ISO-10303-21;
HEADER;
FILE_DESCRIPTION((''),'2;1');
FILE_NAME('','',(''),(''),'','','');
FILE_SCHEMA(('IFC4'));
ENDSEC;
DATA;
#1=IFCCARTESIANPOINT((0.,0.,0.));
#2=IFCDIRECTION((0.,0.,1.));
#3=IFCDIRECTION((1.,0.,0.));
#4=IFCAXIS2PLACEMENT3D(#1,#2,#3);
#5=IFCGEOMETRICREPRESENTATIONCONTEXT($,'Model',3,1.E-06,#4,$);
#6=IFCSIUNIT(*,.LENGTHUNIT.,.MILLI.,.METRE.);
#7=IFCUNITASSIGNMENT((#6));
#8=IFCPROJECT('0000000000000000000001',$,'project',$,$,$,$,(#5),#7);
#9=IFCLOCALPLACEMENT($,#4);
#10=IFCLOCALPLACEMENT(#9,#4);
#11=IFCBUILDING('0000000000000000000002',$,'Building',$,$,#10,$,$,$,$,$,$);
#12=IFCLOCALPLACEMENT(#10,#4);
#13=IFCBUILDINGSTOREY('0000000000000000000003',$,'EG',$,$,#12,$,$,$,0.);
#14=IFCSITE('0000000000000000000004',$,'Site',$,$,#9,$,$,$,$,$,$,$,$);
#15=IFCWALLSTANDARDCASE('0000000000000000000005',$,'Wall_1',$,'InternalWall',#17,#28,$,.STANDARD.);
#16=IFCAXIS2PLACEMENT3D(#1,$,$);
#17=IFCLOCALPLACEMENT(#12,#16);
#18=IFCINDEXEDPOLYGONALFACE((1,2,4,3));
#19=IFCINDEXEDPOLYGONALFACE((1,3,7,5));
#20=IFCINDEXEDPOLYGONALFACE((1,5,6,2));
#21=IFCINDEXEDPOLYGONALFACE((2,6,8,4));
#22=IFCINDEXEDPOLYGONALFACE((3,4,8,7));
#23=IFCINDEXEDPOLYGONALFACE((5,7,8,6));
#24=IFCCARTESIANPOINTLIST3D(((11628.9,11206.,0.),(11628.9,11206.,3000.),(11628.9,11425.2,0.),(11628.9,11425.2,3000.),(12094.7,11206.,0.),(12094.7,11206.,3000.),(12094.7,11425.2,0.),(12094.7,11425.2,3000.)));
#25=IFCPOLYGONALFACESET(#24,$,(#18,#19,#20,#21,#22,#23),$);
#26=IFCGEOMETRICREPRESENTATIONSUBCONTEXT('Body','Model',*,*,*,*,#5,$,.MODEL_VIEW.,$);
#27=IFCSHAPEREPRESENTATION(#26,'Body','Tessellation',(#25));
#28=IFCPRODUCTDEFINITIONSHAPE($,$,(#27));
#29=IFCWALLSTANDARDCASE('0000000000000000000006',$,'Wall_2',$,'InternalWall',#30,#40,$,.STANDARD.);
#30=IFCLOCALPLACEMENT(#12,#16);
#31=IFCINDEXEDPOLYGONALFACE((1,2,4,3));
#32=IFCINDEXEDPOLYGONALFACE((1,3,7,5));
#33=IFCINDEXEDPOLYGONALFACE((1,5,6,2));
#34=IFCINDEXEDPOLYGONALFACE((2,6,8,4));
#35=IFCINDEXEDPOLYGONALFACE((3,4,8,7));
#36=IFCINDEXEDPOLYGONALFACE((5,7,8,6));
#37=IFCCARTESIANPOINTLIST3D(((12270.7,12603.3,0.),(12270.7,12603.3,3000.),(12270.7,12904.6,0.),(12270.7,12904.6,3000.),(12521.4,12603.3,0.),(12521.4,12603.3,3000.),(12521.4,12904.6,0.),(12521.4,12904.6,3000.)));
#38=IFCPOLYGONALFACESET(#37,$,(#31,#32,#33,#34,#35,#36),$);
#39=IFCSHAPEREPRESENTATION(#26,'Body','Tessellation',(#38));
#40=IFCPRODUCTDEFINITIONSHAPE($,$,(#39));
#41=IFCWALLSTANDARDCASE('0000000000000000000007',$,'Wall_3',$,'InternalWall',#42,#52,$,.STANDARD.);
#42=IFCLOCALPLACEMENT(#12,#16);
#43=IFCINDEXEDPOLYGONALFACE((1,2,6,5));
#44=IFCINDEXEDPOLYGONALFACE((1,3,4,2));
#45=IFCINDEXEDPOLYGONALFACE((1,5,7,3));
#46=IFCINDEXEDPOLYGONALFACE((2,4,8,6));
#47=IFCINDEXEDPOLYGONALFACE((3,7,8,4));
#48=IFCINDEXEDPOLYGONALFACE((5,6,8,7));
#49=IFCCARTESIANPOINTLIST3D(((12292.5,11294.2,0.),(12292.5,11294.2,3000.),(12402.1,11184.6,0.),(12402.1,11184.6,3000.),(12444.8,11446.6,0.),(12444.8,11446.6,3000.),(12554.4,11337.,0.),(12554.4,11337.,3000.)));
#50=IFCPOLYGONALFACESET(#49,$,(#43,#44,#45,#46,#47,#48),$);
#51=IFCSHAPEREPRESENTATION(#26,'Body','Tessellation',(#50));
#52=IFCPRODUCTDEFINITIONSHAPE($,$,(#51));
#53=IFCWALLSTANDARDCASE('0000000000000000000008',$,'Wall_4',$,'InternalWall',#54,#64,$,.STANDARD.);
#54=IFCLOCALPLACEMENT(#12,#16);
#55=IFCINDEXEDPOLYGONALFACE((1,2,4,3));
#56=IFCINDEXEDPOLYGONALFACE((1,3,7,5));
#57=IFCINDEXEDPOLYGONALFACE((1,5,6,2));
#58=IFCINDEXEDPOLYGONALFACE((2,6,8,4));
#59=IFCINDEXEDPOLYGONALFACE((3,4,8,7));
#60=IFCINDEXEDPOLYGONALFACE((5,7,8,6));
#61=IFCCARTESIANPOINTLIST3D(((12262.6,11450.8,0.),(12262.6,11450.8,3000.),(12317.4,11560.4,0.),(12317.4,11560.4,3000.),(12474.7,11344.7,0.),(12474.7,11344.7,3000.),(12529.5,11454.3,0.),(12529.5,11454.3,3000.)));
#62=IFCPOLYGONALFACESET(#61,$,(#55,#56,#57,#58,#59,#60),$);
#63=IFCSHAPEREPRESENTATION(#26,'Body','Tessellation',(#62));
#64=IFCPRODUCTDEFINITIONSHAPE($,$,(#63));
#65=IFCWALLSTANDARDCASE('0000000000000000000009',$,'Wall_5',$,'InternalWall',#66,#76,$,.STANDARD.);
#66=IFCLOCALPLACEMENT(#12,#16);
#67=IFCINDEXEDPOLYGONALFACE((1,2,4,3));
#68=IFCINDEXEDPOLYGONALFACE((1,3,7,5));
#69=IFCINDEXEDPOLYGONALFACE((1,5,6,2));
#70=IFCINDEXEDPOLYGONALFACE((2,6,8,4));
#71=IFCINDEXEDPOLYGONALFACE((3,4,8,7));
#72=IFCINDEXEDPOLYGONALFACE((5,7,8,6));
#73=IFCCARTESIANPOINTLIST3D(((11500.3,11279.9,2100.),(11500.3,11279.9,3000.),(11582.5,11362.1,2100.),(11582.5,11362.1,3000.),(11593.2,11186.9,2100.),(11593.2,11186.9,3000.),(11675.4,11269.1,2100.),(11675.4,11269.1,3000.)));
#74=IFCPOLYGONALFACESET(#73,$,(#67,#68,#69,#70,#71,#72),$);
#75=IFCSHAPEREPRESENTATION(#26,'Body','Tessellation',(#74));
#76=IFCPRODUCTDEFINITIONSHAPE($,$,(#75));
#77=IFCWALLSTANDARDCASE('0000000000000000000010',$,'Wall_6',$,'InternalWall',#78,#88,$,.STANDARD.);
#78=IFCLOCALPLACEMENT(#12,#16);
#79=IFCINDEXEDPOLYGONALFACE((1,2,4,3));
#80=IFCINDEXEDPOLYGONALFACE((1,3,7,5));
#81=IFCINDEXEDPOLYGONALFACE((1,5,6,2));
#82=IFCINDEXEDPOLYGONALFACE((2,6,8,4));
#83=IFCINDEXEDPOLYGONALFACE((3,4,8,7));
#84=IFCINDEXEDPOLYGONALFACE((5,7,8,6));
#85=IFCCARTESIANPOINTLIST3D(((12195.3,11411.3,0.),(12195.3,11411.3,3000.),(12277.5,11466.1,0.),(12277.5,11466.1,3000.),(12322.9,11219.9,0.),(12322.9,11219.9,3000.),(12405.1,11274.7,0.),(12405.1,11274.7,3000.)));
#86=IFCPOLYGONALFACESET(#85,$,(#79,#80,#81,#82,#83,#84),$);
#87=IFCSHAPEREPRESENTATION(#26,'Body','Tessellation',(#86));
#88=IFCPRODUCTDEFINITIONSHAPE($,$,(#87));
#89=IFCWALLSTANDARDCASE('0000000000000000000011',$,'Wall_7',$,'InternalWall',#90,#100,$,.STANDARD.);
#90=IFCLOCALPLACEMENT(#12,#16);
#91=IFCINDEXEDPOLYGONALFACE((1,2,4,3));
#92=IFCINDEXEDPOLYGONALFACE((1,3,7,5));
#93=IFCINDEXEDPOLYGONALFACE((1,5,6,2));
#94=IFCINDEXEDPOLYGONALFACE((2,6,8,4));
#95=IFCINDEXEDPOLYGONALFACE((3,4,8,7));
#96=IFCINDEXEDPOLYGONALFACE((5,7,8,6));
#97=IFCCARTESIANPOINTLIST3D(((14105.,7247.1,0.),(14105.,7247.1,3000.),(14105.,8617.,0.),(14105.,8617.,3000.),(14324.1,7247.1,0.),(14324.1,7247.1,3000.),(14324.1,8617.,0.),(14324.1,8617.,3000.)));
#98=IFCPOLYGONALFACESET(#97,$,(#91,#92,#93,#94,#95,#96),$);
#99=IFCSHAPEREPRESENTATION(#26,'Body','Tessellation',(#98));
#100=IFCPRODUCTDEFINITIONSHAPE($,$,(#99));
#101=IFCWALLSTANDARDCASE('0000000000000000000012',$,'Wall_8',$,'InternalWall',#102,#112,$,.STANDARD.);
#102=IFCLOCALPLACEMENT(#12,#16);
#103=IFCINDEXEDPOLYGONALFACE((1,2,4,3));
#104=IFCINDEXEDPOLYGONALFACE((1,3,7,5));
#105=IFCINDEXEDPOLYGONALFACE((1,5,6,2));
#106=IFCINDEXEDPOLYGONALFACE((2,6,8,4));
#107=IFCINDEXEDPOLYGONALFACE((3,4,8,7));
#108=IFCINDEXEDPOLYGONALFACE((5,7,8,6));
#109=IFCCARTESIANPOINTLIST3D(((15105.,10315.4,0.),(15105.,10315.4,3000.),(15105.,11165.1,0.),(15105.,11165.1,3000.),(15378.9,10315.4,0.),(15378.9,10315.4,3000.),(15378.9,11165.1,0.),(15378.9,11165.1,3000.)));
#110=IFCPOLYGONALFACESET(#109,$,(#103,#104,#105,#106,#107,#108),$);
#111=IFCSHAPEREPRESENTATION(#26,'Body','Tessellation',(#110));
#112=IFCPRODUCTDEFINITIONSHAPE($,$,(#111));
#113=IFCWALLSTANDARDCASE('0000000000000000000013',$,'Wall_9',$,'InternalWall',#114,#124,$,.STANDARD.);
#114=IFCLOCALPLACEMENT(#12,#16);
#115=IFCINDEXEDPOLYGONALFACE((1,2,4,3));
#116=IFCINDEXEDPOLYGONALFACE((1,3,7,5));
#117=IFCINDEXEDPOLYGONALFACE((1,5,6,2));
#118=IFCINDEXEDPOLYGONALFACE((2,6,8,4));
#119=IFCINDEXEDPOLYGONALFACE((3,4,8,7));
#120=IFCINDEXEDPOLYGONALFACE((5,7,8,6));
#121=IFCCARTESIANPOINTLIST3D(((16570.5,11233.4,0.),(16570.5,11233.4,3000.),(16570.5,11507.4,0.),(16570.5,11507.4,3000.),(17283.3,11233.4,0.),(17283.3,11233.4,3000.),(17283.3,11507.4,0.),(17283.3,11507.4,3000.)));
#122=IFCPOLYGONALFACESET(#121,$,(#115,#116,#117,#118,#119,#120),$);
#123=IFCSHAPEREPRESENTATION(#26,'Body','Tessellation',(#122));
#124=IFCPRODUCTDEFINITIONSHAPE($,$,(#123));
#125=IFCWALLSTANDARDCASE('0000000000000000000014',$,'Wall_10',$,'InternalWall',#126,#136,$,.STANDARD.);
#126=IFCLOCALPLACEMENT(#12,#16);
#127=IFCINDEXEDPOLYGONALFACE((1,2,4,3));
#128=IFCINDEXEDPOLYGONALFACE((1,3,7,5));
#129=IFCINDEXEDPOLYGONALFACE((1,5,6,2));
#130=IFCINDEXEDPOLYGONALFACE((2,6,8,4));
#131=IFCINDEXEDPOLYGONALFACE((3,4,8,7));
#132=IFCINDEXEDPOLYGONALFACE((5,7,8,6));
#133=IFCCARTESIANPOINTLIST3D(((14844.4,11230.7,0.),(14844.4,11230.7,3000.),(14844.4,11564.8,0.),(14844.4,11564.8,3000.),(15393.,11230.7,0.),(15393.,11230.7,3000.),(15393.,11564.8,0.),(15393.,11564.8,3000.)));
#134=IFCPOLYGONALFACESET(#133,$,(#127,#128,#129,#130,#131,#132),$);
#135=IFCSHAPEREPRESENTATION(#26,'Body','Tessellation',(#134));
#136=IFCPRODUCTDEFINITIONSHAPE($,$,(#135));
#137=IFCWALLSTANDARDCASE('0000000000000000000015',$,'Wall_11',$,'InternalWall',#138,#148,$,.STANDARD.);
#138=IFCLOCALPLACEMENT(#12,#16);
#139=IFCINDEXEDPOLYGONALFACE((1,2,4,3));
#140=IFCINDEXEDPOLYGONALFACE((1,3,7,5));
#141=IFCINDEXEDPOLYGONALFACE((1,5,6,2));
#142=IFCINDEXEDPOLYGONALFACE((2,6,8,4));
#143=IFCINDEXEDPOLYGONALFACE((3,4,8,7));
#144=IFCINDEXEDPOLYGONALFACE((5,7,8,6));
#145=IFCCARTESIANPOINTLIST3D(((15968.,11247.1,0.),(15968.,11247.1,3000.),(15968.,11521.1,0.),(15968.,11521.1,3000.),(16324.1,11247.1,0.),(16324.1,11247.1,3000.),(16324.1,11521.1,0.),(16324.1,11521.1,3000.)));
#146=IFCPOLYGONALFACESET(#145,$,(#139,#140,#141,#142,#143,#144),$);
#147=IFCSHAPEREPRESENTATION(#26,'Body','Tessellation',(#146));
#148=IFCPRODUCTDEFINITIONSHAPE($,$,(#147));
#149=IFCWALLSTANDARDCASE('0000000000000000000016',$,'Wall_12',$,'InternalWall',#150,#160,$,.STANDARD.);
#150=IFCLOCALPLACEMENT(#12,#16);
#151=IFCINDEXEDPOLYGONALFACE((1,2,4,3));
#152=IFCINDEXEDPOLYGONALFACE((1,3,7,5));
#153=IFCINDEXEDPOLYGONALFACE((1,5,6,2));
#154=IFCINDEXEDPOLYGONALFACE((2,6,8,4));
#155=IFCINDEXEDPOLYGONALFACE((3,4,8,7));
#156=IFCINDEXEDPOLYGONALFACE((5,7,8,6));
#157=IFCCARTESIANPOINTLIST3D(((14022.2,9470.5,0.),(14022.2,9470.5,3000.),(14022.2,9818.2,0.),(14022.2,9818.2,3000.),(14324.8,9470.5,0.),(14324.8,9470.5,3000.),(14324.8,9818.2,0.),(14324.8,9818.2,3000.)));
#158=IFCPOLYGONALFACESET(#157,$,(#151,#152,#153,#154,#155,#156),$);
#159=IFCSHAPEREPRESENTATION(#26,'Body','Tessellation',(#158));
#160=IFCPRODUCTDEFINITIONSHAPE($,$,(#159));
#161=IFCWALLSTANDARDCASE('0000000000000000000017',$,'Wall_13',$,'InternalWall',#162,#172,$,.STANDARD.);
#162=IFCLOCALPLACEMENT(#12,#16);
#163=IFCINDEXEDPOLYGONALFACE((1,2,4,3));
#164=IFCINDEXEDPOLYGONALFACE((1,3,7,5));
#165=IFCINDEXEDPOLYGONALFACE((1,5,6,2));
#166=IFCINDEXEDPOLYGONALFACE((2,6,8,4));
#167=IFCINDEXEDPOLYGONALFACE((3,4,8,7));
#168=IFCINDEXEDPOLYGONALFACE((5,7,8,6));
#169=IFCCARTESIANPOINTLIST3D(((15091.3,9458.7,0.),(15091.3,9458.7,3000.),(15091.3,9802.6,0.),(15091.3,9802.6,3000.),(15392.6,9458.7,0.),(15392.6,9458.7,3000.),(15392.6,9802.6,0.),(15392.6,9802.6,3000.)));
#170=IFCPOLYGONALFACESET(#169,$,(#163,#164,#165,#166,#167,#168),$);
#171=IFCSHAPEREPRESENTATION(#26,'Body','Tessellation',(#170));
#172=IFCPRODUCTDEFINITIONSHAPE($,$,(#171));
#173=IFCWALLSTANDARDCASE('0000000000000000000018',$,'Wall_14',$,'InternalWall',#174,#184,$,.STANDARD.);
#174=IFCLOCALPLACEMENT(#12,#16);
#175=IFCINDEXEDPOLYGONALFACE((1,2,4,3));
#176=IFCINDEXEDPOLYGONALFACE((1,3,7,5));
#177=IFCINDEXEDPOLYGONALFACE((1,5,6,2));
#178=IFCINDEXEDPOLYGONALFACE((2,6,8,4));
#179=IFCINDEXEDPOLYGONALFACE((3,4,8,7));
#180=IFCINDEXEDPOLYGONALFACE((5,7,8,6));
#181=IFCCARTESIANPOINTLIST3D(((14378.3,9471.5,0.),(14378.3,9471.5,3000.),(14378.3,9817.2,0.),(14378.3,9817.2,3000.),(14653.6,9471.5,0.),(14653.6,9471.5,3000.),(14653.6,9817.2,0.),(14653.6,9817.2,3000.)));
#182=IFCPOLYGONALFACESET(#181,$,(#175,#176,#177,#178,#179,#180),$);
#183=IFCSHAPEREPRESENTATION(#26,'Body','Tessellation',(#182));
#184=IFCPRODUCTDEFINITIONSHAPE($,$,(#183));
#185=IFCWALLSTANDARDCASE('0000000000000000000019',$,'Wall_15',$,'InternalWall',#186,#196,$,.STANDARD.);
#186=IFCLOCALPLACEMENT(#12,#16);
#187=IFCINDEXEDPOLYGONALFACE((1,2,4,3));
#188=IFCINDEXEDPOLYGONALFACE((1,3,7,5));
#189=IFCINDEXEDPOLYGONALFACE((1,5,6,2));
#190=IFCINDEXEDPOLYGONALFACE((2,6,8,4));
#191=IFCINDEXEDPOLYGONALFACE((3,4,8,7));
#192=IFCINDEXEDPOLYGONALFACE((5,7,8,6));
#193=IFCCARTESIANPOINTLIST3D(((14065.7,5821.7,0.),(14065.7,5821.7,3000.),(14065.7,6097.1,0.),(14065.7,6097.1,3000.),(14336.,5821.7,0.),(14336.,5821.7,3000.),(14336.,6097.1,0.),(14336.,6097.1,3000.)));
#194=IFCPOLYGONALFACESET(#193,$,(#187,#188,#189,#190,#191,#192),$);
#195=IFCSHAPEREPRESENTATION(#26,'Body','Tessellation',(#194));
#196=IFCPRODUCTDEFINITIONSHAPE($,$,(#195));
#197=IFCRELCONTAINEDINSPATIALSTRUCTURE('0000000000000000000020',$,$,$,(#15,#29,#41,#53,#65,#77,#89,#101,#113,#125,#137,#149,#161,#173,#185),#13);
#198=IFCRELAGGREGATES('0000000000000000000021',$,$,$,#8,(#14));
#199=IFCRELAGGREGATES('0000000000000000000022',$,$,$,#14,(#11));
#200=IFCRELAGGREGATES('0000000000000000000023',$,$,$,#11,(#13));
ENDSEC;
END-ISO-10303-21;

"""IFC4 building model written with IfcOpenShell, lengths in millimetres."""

from ifc_helpers import new_model, si_unit, frame, origin_with_axes, place, context, subcontext, project, spatial, rectangle, extrude, element, save


model = new_model("IFC4")

# Units and contexts
model_context = context("Model", 3, precision=1e-06, world=origin_with_axes())
body_context = subcontext(model_context, "Body", "Model", "MODEL_VIEW")
ifc_project = project(units=[si_unit("LENGTHUNIT", "METRE", prefix="MILLI")], contexts=[model_context])

# Site, building, storey
site_placement = place(None, origin_with_axes())
site = spatial("IfcSite", under=ifc_project, at=site_placement, Name="Site")
building_placement = place(site_placement, origin_with_axes())
building = spatial("IfcBuilding", under=site, at=building_placement, Name="Building")
storey_placement = place(building_placement, origin_with_axes())
storey = spatial("IfcBuildingStorey", under=building, at=storey_placement, Name="EG", Elevation=0.0)

# Walls
wall_1_placement = place(storey_placement, origin_with_axes())
element("IfcWallStandardCase", 1, at=wall_1_placement, inside=storey, Name="Wall_1", ObjectType="InternalWall", PredefinedType="STANDARD", context=body_context, shape_type="SweptSolid", body=[
    extrude(rectangle(XDim=465.8, YDim=219.2), frame((11861.8, 11315.6, 0.0), z_axis=(0.0, 0.0, 1.0), x_axis=(-1.0, 0.0, 0.0)), (0.0, 0.0, 1.0), 3000.0),
])
wall_2_placement = place(storey_placement, origin_with_axes())
element("IfcWallStandardCase", 2, at=wall_2_placement, inside=storey, Name="Wall_2", ObjectType="InternalWall", PredefinedType="STANDARD", context=body_context, shape_type="SweptSolid", body=[
    extrude(rectangle(XDim=301.4, YDim=250.8), frame((12396.1, 12753.9, 0.0), z_axis=(0.0, 0.0, 1.0), x_axis=(0.0, -1.0, 0.0)), (0.0, 0.0, 1.0), 3000.0),
])
wall_3_placement = place(storey_placement, origin_with_axes())
element("IfcWallStandardCase", 3, at=wall_3_placement, inside=storey, Name="Wall_3", ObjectType="InternalWall", PredefinedType="STANDARD", context=body_context, shape_type="SweptSolid", body=[
    extrude(rectangle(XDim=155.0, YDim=215.5), frame((12423.5, 11315.6, 0.0), z_axis=(0.0, 0.0, 1.0), x_axis=(0.707107, -0.707107, 0.0)), (0.0, 0.0, 1.0), 3000.0),
])
wall_4_placement = place(storey_placement, origin_with_axes())
element("IfcWallStandardCase", 4, at=wall_4_placement, inside=storey, Name="Wall_4", ObjectType="InternalWall", PredefinedType="STANDARD", context=body_context, shape_type="SweptSolid", body=[
    extrude(rectangle(XDim=122.5, YDim=237.2), frame((12396.1, 11452.6, 0.0), z_axis=(0.0, 0.0, 1.0), x_axis=(-0.447214, -0.894427, 0.0)), (0.0, 0.0, 1.0), 3000.0),
])

# Wall, opening
wall_5_placement = place(storey_placement, origin_with_axes())
wall_5 = element("IfcWallStandardCase", 5, at=wall_5_placement, inside=storey, Name="Wall_5", ObjectType="InternalWall", PredefinedType="STANDARD", context=body_context, shape_type="SweptSolid", body=[
    extrude(rectangle(XDim=116.2, YDim=131.5), frame((11587.8, 11274.5, 0.0), z_axis=(0.0, 0.0, 1.0), x_axis=(-0.707107, -0.707107, 0.0)), (0.0, 0.0, 1.0), 3000.0),
])
opening_1_placement = place(wall_5_placement, origin_with_axes())
element("IfcOpeningElement", 6, at=opening_1_placement, inside=storey, cuts=wall_5, context=body_context, shape_type="SweptSolid", body=[
    extrude(rectangle(XDim=450.0, YDim=131.5), frame((11587.8, 11274.5, 0.0), z_axis=(0.0, 0.0, 1.0), x_axis=(-0.707107, -0.707107, 0.0)), (0.0, 0.0, 1.0), 2100.0),
])

# Walls
wall_6_placement = place(storey_placement, origin_with_axes())
element("IfcWallStandardCase", 7, at=wall_6_placement, inside=storey, Name="Wall_6", ObjectType="InternalWall", PredefinedType="STANDARD", context=body_context, shape_type="SweptSolid", body=[
    extrude(rectangle(XDim=98.8, YDim=230.0), frame((12300.2, 11343.0, 0.0), z_axis=(0.0, 0.0, 1.0), x_axis=(-0.83205, -0.5547, 0.0)), (0.0, 0.0, 1.0), 3000.0),
])
wall_7_placement = place(storey_placement, origin_with_axes())
element("IfcWallStandardCase", 8, at=wall_7_placement, inside=storey, Name="Wall_7", ObjectType="InternalWall", PredefinedType="STANDARD", context=body_context, shape_type="SweptSolid", body=[
    extrude(rectangle(XDim=1369.9, YDim=219.2), frame((14214.6, 7932.0, 0.0), z_axis=(0.0, 0.0, 1.0), x_axis=(0.0, -1.0, 0.0)), (0.0, 0.0, 1.0), 3000.0),
])
wall_8_placement = place(storey_placement, origin_with_axes())
element("IfcWallStandardCase", 9, at=wall_8_placement, inside=storey, Name="Wall_8", ObjectType="InternalWall", PredefinedType="STANDARD", context=body_context, shape_type="SweptSolid", body=[
    extrude(rectangle(XDim=849.8, YDim=274.0), frame((15242.0, 10740.2, 0.0), z_axis=(0.0, 0.0, 1.0), x_axis=(0.0, 1.0, 0.0)), (0.0, 0.0, 1.0), 3000.0),
])
wall_9_placement = place(storey_placement, origin_with_axes())
element("IfcWallStandardCase", 10, at=wall_9_placement, inside=storey, Name="Wall_9", ObjectType="InternalWall", PredefinedType="STANDARD", context=body_context, shape_type="SweptSolid", body=[
    extrude(rectangle(XDim=712.9, YDim=274.0), frame((16926.9, 11370.4, 0.0), z_axis=(0.0, 0.0, 1.0), x_axis=(1.0, 0.0, 0.0)), (0.0, 0.0, 1.0), 3000.0),
])
wall_10_placement = place(storey_placement, origin_with_axes())
element("IfcWallStandardCase", 11, at=wall_10_placement, inside=storey, Name="Wall_10", ObjectType="InternalWall", PredefinedType="STANDARD", context=body_context, shape_type="SweptSolid", body=[
    extrude(rectangle(XDim=548.6, YDim=334.1), frame((15118.7, 11397.8, 0.0), z_axis=(0.0, 0.0, 1.0), x_axis=(1.0, 0.0, 0.0)), (0.0, 0.0, 1.0), 3000.0),
])
wall_11_placement = place(storey_placement, origin_with_axes())
element("IfcWallStandardCase", 12, at=wall_11_placement, inside=storey, Name="Wall_11", ObjectType="InternalWall", PredefinedType="STANDARD", context=body_context, shape_type="SweptSolid", body=[
    extrude(rectangle(XDim=356.2, YDim=274.0), frame((16146.1, 11384.1, 0.0), z_axis=(0.0, 0.0, 1.0), x_axis=(-1.0, 0.0, 0.0)), (0.0, 0.0, 1.0), 3000.0),
])
wall_12_placement = place(storey_placement, origin_with_axes())
element("IfcWallStandardCase", 13, at=wall_12_placement, inside=storey, Name="Wall_12", ObjectType="InternalWall", PredefinedType="STANDARD", context=body_context, shape_type="SweptSolid", body=[
    extrude(rectangle(XDim=302.6, YDim=347.7), frame((14173.5, 9644.3, 0.0), z_axis=(0.0, 0.0, 1.0), x_axis=(1.0, 0.0, 0.0)), (0.0, 0.0, 1.0), 3000.0),
])
wall_13_placement = place(storey_placement, origin_with_axes())
element("IfcWallStandardCase", 14, at=wall_13_placement, inside=storey, Name="Wall_13", ObjectType="InternalWall", PredefinedType="STANDARD", context=body_context, shape_type="SweptSolid", body=[
    extrude(rectangle(XDim=301.4, YDim=343.9), frame((15242.0, 9630.7, 0.0), z_axis=(0.0, 0.0, 1.0), x_axis=(1.0, 0.0, 0.0)), (0.0, 0.0, 1.0), 3000.0),
])
wall_14_placement = place(storey_placement, origin_with_axes())
element("IfcWallStandardCase", 15, at=wall_14_placement, inside=storey, Name="Wall_14", ObjectType="InternalWall", PredefinedType="STANDARD", context=body_context, shape_type="SweptSolid", body=[
    extrude(rectangle(XDim=275.3, YDim=345.6), frame((14515.9, 9644.3, 0.0), z_axis=(0.0, 0.0, 1.0), x_axis=(1.0, 0.0, 0.0)), (0.0, 0.0, 1.0), 3000.0),
])
wall_15_placement = place(storey_placement, origin_with_axes())
element("IfcWallStandardCase", 16, at=wall_15_placement, inside=storey, Name="Wall_15", ObjectType="InternalWall", PredefinedType="STANDARD", context=body_context, shape_type="SweptSolid", body=[
    extrude(rectangle(XDim=275.3, YDim=270.3), frame((14200.9, 5959.4, 0.0), z_axis=(0.0, 0.0, 1.0), x_axis=(0.0, -1.0, 0.0)), (0.0, 0.0, 1.0), 3000.0),
])

save(model, "model.ifc")
